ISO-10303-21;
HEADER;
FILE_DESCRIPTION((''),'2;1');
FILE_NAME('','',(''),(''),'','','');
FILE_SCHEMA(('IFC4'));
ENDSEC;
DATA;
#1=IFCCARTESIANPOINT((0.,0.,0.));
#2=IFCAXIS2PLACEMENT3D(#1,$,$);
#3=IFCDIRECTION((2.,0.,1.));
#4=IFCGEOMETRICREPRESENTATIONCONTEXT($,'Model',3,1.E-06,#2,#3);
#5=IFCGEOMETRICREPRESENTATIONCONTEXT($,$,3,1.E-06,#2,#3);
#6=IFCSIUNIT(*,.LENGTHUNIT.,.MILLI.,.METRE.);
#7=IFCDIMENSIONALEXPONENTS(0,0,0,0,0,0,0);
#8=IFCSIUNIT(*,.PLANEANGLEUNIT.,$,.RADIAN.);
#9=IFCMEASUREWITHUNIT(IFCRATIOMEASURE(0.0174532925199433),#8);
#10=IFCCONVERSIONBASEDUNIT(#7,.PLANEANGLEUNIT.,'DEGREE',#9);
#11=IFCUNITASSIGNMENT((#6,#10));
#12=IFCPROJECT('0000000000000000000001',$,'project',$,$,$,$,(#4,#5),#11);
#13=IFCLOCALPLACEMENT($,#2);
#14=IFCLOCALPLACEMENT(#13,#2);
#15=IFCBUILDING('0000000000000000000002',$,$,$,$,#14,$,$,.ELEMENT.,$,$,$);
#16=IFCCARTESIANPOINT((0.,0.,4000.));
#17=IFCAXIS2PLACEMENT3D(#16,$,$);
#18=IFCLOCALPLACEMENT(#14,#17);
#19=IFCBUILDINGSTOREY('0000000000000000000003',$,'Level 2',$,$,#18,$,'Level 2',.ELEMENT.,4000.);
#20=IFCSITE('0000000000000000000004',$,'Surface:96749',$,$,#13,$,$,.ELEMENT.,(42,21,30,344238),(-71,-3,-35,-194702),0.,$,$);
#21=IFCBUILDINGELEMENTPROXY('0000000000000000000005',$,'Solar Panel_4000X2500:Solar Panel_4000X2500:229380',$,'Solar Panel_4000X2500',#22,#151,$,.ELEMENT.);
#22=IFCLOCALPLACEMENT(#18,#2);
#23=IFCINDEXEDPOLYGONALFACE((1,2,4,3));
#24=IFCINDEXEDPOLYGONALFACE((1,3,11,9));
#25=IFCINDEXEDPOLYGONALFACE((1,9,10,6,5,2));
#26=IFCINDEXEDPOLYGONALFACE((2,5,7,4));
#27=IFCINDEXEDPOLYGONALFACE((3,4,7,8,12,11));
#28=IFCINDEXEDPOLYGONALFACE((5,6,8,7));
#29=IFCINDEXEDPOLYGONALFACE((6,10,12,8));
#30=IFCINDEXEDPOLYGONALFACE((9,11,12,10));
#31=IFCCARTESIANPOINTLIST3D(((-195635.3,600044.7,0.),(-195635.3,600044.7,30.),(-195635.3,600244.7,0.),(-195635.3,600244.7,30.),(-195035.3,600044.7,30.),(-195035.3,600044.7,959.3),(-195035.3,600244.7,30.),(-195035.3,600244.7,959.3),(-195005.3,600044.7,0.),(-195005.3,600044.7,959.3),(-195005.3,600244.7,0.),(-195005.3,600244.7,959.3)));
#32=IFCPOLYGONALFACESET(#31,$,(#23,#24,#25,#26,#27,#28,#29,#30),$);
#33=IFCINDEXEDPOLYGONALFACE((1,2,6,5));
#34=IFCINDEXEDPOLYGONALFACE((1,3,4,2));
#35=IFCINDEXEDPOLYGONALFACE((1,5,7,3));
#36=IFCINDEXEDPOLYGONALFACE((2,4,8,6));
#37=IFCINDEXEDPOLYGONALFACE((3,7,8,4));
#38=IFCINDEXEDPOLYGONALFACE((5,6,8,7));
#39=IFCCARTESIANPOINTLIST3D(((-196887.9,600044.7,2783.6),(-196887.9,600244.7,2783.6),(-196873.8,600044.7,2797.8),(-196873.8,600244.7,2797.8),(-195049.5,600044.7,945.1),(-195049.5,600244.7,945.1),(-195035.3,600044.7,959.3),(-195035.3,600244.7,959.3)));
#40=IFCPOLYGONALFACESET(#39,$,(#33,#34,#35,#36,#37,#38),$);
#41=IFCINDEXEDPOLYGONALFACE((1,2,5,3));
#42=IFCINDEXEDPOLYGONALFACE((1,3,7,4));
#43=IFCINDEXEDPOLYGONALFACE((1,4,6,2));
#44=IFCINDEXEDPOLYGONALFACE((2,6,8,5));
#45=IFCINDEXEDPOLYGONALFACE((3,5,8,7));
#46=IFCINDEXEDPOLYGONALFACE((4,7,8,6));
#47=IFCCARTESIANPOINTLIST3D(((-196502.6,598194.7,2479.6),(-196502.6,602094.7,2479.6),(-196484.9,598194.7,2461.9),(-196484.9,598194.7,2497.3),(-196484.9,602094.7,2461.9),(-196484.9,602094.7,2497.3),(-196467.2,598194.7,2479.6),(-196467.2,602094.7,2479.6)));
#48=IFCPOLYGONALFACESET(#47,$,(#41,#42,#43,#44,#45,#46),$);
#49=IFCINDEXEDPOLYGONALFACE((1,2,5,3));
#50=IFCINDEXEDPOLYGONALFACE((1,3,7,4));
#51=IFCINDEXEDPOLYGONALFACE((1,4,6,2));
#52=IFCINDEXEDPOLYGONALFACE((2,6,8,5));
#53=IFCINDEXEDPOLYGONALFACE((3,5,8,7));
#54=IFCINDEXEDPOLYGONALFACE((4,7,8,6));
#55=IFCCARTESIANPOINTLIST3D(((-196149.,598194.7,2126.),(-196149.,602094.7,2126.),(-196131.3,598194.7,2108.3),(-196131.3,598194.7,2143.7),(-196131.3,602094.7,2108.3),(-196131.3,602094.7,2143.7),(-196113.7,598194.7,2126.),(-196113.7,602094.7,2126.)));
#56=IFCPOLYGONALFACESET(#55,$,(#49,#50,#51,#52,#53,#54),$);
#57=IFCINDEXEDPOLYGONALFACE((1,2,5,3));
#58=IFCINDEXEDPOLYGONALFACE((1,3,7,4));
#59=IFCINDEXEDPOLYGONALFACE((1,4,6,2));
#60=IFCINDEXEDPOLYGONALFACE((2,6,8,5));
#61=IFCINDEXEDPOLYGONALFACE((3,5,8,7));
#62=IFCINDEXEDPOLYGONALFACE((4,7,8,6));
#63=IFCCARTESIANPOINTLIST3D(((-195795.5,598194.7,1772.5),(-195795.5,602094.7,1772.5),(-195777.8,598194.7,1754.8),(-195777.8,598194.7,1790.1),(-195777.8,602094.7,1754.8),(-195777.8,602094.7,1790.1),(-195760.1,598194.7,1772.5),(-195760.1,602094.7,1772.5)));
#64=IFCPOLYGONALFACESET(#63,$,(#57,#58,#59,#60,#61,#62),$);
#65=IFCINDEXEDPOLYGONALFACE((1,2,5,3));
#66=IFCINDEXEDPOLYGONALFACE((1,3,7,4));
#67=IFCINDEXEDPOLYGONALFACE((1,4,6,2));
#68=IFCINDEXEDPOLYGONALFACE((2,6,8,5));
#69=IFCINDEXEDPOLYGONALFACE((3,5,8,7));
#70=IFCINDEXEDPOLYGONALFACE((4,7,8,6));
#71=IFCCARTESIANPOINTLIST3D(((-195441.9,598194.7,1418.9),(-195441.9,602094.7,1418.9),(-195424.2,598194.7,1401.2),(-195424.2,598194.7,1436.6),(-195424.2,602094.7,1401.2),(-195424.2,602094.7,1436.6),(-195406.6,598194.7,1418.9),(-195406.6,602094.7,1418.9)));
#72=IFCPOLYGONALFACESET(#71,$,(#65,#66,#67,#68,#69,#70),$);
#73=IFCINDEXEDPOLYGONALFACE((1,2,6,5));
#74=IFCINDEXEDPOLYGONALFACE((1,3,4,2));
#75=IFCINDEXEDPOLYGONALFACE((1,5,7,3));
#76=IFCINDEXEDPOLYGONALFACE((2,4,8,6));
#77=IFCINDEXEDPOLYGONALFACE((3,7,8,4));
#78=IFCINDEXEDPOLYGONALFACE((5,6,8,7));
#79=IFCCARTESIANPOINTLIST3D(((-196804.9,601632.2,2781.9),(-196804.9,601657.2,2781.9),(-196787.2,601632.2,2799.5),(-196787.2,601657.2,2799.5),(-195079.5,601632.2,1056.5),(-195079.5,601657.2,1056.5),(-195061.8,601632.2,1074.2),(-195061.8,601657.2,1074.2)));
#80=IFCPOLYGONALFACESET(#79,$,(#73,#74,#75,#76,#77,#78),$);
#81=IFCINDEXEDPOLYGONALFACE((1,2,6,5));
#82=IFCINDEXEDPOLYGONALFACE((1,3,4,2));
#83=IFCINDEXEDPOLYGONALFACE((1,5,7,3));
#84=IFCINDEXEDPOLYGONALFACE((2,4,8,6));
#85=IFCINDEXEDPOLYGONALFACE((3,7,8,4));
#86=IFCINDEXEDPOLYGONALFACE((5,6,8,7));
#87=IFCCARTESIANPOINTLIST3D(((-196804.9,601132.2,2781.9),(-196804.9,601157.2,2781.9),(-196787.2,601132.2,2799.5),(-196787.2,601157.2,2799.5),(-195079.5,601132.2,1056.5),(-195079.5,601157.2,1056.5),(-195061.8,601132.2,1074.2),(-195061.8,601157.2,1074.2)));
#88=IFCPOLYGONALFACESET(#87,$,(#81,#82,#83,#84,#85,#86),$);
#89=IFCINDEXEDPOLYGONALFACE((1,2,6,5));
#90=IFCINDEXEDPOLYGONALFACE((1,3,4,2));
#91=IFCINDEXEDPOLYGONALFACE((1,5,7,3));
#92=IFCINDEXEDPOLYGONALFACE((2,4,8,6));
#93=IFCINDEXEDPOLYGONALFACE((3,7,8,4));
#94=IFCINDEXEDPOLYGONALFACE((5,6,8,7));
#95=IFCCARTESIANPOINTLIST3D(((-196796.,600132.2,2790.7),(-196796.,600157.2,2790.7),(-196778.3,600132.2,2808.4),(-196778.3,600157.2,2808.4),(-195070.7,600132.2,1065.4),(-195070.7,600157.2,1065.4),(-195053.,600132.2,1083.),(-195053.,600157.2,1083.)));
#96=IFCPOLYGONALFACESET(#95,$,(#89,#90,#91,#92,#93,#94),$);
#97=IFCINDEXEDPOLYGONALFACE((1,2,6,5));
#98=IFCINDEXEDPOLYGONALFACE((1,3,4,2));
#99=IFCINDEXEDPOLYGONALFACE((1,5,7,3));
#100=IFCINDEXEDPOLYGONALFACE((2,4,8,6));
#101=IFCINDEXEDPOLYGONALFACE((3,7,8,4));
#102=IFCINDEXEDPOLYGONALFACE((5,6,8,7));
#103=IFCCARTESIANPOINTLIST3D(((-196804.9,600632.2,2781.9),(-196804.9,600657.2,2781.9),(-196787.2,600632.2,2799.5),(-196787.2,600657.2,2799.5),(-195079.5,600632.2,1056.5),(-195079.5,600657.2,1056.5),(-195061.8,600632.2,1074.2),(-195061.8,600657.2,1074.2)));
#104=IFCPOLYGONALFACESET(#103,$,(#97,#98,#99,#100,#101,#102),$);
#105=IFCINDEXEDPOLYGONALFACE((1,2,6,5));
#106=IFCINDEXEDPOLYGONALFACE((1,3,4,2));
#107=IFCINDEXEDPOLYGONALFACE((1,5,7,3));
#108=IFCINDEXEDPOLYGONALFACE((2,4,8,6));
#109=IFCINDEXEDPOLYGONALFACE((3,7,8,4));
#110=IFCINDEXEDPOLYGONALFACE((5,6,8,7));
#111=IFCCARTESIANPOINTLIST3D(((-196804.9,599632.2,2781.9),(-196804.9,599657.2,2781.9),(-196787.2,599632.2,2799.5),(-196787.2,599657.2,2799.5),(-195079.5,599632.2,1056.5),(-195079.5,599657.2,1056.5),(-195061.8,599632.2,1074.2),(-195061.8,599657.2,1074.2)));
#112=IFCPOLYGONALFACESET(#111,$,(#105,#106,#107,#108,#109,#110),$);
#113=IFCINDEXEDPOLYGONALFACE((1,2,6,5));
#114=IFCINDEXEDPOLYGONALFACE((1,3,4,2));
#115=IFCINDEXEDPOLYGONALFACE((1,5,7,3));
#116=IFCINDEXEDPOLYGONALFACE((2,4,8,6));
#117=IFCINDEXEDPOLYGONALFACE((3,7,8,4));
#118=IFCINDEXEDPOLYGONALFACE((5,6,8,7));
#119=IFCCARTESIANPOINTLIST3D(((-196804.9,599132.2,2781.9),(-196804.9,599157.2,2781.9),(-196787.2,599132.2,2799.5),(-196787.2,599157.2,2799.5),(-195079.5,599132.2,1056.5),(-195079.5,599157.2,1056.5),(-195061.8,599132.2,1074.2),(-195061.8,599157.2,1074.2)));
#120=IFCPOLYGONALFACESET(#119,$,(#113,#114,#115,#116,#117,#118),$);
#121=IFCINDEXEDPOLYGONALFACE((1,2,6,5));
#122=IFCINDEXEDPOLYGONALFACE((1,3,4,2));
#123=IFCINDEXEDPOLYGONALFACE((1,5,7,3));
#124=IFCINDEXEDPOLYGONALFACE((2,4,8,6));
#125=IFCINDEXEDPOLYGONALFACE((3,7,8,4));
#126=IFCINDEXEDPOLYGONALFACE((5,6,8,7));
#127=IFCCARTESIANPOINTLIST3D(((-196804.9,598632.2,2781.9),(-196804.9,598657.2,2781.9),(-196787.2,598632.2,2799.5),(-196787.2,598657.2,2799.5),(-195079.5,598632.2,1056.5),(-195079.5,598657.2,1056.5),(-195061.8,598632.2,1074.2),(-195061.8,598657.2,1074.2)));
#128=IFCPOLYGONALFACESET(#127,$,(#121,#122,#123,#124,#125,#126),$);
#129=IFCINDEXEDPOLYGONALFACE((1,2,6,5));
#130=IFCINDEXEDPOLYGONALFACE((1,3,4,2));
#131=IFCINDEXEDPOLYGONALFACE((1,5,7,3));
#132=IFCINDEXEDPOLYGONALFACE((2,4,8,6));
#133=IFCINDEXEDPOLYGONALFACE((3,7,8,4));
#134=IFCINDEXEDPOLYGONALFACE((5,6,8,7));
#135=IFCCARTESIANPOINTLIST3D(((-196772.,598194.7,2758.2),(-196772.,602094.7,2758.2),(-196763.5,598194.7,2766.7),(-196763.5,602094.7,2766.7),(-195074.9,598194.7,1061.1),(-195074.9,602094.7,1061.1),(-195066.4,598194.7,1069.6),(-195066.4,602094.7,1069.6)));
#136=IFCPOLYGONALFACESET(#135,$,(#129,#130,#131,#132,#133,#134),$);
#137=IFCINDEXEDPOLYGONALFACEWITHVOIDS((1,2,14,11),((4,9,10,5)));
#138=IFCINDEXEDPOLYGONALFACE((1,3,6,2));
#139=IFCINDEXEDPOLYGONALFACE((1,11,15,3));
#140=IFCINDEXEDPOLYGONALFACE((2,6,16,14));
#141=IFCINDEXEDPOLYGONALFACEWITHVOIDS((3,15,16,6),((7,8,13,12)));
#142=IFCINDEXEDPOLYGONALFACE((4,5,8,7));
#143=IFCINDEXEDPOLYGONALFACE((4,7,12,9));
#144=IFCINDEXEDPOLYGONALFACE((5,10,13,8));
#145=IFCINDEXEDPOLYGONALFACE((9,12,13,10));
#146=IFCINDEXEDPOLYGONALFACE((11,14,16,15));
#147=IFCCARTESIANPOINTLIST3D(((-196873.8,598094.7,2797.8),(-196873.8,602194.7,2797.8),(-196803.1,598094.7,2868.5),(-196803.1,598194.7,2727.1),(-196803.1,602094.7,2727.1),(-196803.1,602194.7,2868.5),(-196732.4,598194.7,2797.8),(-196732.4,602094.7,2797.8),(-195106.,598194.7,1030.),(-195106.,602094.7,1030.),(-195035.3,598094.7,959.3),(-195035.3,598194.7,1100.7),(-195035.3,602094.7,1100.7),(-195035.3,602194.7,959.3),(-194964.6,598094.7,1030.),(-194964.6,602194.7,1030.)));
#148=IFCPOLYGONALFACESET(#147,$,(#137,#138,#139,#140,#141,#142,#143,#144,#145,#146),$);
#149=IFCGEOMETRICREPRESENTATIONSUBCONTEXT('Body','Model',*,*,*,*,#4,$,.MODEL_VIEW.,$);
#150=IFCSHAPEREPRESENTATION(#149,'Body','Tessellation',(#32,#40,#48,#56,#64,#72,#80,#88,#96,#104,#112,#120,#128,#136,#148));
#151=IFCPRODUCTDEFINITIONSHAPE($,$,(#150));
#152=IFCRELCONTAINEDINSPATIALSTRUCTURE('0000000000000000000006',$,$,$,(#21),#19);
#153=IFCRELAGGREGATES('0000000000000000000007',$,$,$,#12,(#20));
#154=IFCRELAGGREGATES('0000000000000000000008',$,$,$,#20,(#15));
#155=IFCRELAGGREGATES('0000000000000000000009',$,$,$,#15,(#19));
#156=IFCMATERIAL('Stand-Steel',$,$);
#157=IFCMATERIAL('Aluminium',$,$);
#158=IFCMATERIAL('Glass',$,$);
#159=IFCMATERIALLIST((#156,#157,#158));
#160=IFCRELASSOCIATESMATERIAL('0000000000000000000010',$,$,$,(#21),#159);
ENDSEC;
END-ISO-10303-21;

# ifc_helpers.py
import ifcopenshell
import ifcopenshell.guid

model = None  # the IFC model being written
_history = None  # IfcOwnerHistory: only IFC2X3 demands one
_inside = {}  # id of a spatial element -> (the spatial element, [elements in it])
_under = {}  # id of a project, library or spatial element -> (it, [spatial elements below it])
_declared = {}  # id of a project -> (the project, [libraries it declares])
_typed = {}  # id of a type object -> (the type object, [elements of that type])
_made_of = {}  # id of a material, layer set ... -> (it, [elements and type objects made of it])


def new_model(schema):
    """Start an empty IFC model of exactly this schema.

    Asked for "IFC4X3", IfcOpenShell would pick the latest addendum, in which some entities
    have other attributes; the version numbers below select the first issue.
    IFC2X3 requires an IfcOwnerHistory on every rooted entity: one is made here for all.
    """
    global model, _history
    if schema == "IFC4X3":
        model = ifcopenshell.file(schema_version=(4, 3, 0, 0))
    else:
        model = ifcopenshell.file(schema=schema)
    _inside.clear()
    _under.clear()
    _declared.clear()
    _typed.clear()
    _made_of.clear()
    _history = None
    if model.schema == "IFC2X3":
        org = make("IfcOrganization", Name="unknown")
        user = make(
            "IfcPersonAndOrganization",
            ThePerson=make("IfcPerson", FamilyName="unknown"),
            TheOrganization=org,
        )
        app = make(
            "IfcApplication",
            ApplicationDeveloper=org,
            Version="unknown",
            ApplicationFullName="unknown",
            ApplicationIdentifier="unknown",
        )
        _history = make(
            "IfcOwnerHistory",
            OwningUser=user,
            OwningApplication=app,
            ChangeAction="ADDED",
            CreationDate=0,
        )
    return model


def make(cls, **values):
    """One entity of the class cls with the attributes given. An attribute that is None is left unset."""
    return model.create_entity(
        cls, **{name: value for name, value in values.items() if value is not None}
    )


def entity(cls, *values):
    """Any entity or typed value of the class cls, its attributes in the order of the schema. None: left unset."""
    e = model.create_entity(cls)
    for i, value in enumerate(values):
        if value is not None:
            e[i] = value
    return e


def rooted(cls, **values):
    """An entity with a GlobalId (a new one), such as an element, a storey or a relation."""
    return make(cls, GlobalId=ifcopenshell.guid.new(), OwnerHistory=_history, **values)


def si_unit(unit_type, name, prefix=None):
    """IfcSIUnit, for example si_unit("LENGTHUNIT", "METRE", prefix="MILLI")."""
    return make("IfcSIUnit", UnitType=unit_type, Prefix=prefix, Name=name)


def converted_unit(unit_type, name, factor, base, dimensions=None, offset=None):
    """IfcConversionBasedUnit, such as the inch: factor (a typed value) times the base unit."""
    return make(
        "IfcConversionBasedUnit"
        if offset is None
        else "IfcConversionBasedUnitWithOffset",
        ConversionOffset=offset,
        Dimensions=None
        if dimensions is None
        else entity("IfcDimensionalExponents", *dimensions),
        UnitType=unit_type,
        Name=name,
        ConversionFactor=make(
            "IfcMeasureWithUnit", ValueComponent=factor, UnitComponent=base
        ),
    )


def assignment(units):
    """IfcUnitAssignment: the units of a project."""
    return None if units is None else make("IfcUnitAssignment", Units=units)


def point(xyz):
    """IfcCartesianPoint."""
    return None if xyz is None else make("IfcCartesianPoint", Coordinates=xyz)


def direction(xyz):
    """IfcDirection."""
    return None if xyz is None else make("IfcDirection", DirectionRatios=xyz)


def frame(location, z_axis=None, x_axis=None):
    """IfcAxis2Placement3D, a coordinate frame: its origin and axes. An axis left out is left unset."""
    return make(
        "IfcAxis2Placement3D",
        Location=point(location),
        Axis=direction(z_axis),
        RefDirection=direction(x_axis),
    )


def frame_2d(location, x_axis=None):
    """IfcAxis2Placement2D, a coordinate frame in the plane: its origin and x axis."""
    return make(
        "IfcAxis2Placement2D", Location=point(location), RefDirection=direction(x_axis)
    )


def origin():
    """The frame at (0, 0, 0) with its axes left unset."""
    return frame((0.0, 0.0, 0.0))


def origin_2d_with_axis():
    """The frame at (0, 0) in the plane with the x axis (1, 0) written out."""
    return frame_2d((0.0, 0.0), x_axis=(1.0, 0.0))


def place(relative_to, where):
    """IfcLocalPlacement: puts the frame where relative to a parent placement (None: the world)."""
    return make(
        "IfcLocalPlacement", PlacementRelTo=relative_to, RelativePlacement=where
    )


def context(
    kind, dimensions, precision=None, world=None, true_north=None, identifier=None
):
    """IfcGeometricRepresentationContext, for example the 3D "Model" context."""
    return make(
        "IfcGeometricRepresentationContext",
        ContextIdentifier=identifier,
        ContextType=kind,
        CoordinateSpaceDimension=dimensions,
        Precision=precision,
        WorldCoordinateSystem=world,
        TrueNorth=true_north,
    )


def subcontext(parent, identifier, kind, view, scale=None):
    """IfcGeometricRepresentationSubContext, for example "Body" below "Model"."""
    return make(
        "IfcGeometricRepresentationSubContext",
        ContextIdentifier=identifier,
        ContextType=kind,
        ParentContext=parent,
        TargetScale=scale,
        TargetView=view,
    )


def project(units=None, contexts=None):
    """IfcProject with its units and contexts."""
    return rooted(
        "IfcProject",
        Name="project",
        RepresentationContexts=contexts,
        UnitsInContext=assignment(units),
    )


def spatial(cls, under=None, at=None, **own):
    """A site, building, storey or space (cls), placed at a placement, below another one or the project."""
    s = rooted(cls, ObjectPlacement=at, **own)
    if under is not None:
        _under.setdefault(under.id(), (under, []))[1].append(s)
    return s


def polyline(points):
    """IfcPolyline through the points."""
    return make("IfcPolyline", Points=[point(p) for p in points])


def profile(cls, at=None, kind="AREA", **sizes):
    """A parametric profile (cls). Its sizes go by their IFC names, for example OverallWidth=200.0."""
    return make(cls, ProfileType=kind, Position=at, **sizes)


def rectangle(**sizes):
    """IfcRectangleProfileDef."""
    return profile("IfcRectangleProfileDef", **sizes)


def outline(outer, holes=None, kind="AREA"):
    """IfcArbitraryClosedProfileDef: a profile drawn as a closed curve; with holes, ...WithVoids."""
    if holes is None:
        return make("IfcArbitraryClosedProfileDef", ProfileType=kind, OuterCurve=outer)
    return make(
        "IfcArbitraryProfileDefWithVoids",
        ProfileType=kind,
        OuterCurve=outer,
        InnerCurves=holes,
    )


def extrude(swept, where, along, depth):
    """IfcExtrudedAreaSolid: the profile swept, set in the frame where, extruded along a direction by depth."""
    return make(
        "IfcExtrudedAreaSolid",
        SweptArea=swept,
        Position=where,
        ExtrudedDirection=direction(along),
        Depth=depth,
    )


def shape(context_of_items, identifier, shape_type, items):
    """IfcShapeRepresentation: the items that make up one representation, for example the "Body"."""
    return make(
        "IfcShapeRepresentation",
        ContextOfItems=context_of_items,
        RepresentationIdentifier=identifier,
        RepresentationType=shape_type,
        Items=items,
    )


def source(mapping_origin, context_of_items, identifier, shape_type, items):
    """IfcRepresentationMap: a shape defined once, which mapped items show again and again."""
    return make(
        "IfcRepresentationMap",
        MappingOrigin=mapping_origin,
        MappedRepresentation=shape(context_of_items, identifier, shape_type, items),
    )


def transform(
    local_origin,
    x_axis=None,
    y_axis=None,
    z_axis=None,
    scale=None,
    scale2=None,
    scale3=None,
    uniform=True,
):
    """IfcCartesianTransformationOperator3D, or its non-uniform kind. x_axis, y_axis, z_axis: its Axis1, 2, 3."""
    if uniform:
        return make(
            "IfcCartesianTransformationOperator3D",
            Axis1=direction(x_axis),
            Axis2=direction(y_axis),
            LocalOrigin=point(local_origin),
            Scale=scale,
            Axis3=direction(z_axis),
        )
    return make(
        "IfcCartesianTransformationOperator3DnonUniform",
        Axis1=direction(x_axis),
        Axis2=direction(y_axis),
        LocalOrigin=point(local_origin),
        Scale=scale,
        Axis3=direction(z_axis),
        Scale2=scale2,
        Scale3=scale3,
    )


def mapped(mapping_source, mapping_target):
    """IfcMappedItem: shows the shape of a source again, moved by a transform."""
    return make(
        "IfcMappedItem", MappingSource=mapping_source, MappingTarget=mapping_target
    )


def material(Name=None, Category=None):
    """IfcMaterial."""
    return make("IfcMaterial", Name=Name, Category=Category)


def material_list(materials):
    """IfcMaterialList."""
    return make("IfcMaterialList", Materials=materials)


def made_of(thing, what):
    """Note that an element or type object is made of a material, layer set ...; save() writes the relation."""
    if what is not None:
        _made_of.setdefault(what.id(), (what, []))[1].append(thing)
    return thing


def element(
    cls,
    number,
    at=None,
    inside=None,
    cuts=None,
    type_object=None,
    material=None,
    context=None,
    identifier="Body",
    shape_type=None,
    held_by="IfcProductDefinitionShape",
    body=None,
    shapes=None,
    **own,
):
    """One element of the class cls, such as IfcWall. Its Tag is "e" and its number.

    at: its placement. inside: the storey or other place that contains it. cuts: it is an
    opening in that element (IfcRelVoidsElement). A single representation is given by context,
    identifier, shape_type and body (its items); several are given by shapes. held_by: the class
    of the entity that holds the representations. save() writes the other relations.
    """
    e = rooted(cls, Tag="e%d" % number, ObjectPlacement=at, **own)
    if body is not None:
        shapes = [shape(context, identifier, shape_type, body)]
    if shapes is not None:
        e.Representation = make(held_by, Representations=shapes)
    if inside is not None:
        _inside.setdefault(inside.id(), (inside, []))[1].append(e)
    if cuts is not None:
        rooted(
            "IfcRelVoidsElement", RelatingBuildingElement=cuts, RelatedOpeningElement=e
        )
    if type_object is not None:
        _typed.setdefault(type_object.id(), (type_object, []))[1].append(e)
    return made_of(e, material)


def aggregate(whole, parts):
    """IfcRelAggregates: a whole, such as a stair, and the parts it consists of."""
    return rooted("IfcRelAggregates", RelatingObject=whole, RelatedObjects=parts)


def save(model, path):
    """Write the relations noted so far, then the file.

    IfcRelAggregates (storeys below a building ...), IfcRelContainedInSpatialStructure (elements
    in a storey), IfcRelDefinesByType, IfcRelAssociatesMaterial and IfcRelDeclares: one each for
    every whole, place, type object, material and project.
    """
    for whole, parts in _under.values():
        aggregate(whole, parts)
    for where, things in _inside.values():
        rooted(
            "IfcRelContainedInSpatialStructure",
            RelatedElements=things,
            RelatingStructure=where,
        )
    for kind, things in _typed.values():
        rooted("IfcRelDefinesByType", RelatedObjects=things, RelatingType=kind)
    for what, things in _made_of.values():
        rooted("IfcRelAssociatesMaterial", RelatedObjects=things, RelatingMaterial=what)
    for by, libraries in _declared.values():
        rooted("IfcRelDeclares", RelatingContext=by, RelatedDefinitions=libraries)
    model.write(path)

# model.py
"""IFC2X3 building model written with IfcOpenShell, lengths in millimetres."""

from ifc_helpers import new_model, entity, si_unit, converted_unit, direction, frame, frame_2d, origin, origin_2d_with_axis, place, context, subcontext, project, spatial, polyline, rectangle, outline, extrude, source, transform, mapped, material, material_list, element, save


model = new_model("IFC2X3")

# Units and contexts
model_context = context("Model", 3, precision=1e-06, world=origin(), true_north=direction((2.0, 0.0, 1.0)))
context_of_model = context(None, 3, precision=1e-06, world=origin(), true_north=direction((2.0, 0.0, 1.0)))
body_context = subcontext(model_context, "Body", "Model", "MODEL_VIEW")
ifc_project = project(units=[si_unit("LENGTHUNIT", "METRE", prefix="MILLI"), converted_unit("PLANEANGLEUNIT", "DEGREE", entity("IfcRatioMeasure", 0.0174532925199433), si_unit("PLANEANGLEUNIT", "RADIAN"), dimensions=[0, 0, 0, 0, 0, 0, 0])], contexts=[model_context, context_of_model])

# Site, building, storey
site_placement = place(None, origin())
site = spatial("IfcSite", under=ifc_project, at=site_placement, Name="Surface:96749", CompositionType="ELEMENT", RefLatitude=(42, 21, 30, 344238), RefLongitude=(-71, -3, -35, -194702), RefElevation=0.0)
building_placement = place(site_placement, origin())
building = spatial("IfcBuilding", under=site, at=building_placement, CompositionType="ELEMENT")
storey_placement = place(building_placement, frame((0.0, 0.0, 4000.0)))
storey = spatial("IfcBuildingStorey", under=building, at=storey_placement, Name="Level 2", LongName="Level 2", CompositionType="ELEMENT", Elevation=4000.0)

# Building element proxy
ifc_material_1 = material(Name="Stand-Steel")
ifc_material_2 = material(Name="Aluminium")
ifc_material_3 = material(Name="Glass")
shared_shape = source(origin(), body_context, "Body", "SweptSolid", [
    extrude(outline(polyline([(-629.5, -220.0), (329.8, -220.0), (329.8, 410.0), (299.8, 410.0), (299.8, -190.0), (-629.5, -190.0), (-629.5, -220.0)])), frame((-190.0, -100.0, 299.8), z_axis=(0.0, 1.0, 0.0), x_axis=(0.0, 0.0, -1.0)), (0.0, 0.0, 1.0), 200.0),
    extrude(rectangle(XDim=20.0, YDim=200.0, at=frame_2d((0.0, 0.0), x_axis=(0.0, 1.0))), frame((-7.1, 0.0, 922.2), z_axis=(-0.707107, 0.0, 0.707107), x_axis=(0.0, 1.0, 0.0)), (0.0, 0.0, 1.0), 2600.0),
    extrude(rectangle(XDim=25.0, YDim=25.0, at=frame_2d((0.0, 0.0), x_axis=(1.0, 0.0))), frame((-1449.6, -1950.0, 2449.6), z_axis=(0.0, 1.0, 0.0), x_axis=(-0.707107, 0.0, -0.707107)), (0.0, 0.0, 1.0), 3900.0),
    extrude(rectangle(XDim=25.0, YDim=25.0, at=origin_2d_with_axis()), frame((-1096.0, -1950.0, 2096.0), z_axis=(0.0, 1.0, 0.0), x_axis=(-0.707107, 0.0, -0.707107)), (0.0, 0.0, 1.0), 3900.0),
    extrude(rectangle(XDim=25.0, YDim=25.0, at=origin_2d_with_axis()), frame((-742.5, -1950.0, 1742.5), z_axis=(0.0, 1.0, 0.0), x_axis=(-0.707107, 0.0, -0.707107)), (0.0, 0.0, 1.0), 3900.0),
    extrude(rectangle(XDim=25.0, YDim=25.0, at=frame_2d((0.0, 0.0), x_axis=(1.0, 0.0))), frame((-388.9, -1950.0, 1388.9), z_axis=(0.0, 1.0, 0.0), x_axis=(-0.707107, 0.0, -0.707107)), (0.0, 0.0, 1.0), 3900.0),
    extrude(rectangle(XDim=25.0, YDim=25.0, at=frame_2d((0.0, 0.0), x_axis=(0.0, 1.0))), frame((-35.4, 1500.0, 1035.4), z_axis=(-0.707107, 0.0, 0.707107), x_axis=(0.0, 1.0, 0.0)), (0.0, 0.0, 1.0), 2440.0),
    extrude(rectangle(XDim=25.0, YDim=25.0, at=frame_2d((0.0, 0.0), x_axis=(0.0, 1.0))), frame((-35.4, 1000.0, 1035.4), z_axis=(-0.707107, 0.0, 0.707107), x_axis=(0.0, 1.0, 0.0)), (0.0, 0.0, 1.0), 2440.0),
    extrude(rectangle(XDim=25.0, YDim=25.0, at=frame_2d((0.0, 0.0), x_axis=(0.0, 1.0))), frame((-26.5, 0.0, 1044.2), z_axis=(-0.707107, 0.0, 0.707107), x_axis=(0.0, -1.0, 0.0)), (0.0, 0.0, 1.0), 2440.0),
    extrude(rectangle(XDim=25.0, YDim=25.0, at=frame_2d((0.0, 0.0), x_axis=(0.0, 1.0))), frame((-35.4, 500.0, 1035.4), z_axis=(-0.707107, 0.0, 0.707107), x_axis=(0.0, 1.0, 0.0)), (0.0, 0.0, 1.0), 2440.0),
    extrude(rectangle(XDim=25.0, YDim=25.0, at=frame_2d((0.0, 0.0), x_axis=(0.0, 1.0))), frame((-35.4, -500.0, 1035.4), z_axis=(-0.707107, 0.0, 0.707107), x_axis=(0.0, 1.0, 0.0)), (0.0, 0.0, 1.0), 2440.0),
    extrude(rectangle(XDim=25.0, YDim=25.0, at=frame_2d((0.0, 0.0), x_axis=(0.0, 1.0))), frame((-35.4, -1000.0, 1035.4), z_axis=(-0.707107, 0.0, 0.707107), x_axis=(0.0, 1.0, 0.0)), (0.0, 0.0, 1.0), 2440.0),
    extrude(rectangle(XDim=25.0, YDim=25.0, at=frame_2d((0.0, 0.0), x_axis=(0.0, 1.0))), frame((-35.4, -1500.0, 1035.4), z_axis=(-0.707107, 0.0, 0.707107), x_axis=(0.0, 1.0, 0.0)), (0.0, 0.0, 1.0), 2440.0),
    extrude(rectangle(XDim=2400.0, YDim=12.0, at=frame_2d((0.0, 0.0), x_axis=(1.0, 0.0))), frame((-883.9, -1950.0, 1883.9), z_axis=(0.0, 1.0, 0.0), x_axis=(0.707107, 0.0, -0.707107)), (0.0, 0.0, 1.0), 3900.0),
    extrude(outline(polyline([(-2050.0, -1300.0), (2050.0, -1300.0), (2050.0, 1300.0), (-2050.0, 1300.0), (-2050.0, -1300.0)]), holes=[polyline([(1950.0, -1200.0), (-1950.0, -1200.0), (-1950.0, 1200.0), (1950.0, 1200.0), (1950.0, -1200.0)])]), frame((-919.2, 0.0, 1848.5), z_axis=(0.707107, 0.0, 0.707107), x_axis=(0.0, 1.0, 0.0)), (0.0, 0.0, 1.0), 100.0),
])
ifc_material_list_1 = material_list([ifc_material_1, ifc_material_2, ifc_material_3])
proxy_1_placement = place(storey_placement, frame((-195035.3, 600144.7, 30.0)))
element("IfcBuildingElementProxy", 1, at=proxy_1_placement, inside=storey, material=ifc_material_list_1, Name="Solar Panel_4000X2500:Solar Panel_4000X2500:229380", ObjectType="Solar Panel_4000X2500", CompositionType="ELEMENT", context=body_context, shape_type="MappedRepresentation", body=[
    mapped(shared_shape, transform((0.0, 0.0, 0.0), scale=1.0)),
])

save(model, "model.ifc")
